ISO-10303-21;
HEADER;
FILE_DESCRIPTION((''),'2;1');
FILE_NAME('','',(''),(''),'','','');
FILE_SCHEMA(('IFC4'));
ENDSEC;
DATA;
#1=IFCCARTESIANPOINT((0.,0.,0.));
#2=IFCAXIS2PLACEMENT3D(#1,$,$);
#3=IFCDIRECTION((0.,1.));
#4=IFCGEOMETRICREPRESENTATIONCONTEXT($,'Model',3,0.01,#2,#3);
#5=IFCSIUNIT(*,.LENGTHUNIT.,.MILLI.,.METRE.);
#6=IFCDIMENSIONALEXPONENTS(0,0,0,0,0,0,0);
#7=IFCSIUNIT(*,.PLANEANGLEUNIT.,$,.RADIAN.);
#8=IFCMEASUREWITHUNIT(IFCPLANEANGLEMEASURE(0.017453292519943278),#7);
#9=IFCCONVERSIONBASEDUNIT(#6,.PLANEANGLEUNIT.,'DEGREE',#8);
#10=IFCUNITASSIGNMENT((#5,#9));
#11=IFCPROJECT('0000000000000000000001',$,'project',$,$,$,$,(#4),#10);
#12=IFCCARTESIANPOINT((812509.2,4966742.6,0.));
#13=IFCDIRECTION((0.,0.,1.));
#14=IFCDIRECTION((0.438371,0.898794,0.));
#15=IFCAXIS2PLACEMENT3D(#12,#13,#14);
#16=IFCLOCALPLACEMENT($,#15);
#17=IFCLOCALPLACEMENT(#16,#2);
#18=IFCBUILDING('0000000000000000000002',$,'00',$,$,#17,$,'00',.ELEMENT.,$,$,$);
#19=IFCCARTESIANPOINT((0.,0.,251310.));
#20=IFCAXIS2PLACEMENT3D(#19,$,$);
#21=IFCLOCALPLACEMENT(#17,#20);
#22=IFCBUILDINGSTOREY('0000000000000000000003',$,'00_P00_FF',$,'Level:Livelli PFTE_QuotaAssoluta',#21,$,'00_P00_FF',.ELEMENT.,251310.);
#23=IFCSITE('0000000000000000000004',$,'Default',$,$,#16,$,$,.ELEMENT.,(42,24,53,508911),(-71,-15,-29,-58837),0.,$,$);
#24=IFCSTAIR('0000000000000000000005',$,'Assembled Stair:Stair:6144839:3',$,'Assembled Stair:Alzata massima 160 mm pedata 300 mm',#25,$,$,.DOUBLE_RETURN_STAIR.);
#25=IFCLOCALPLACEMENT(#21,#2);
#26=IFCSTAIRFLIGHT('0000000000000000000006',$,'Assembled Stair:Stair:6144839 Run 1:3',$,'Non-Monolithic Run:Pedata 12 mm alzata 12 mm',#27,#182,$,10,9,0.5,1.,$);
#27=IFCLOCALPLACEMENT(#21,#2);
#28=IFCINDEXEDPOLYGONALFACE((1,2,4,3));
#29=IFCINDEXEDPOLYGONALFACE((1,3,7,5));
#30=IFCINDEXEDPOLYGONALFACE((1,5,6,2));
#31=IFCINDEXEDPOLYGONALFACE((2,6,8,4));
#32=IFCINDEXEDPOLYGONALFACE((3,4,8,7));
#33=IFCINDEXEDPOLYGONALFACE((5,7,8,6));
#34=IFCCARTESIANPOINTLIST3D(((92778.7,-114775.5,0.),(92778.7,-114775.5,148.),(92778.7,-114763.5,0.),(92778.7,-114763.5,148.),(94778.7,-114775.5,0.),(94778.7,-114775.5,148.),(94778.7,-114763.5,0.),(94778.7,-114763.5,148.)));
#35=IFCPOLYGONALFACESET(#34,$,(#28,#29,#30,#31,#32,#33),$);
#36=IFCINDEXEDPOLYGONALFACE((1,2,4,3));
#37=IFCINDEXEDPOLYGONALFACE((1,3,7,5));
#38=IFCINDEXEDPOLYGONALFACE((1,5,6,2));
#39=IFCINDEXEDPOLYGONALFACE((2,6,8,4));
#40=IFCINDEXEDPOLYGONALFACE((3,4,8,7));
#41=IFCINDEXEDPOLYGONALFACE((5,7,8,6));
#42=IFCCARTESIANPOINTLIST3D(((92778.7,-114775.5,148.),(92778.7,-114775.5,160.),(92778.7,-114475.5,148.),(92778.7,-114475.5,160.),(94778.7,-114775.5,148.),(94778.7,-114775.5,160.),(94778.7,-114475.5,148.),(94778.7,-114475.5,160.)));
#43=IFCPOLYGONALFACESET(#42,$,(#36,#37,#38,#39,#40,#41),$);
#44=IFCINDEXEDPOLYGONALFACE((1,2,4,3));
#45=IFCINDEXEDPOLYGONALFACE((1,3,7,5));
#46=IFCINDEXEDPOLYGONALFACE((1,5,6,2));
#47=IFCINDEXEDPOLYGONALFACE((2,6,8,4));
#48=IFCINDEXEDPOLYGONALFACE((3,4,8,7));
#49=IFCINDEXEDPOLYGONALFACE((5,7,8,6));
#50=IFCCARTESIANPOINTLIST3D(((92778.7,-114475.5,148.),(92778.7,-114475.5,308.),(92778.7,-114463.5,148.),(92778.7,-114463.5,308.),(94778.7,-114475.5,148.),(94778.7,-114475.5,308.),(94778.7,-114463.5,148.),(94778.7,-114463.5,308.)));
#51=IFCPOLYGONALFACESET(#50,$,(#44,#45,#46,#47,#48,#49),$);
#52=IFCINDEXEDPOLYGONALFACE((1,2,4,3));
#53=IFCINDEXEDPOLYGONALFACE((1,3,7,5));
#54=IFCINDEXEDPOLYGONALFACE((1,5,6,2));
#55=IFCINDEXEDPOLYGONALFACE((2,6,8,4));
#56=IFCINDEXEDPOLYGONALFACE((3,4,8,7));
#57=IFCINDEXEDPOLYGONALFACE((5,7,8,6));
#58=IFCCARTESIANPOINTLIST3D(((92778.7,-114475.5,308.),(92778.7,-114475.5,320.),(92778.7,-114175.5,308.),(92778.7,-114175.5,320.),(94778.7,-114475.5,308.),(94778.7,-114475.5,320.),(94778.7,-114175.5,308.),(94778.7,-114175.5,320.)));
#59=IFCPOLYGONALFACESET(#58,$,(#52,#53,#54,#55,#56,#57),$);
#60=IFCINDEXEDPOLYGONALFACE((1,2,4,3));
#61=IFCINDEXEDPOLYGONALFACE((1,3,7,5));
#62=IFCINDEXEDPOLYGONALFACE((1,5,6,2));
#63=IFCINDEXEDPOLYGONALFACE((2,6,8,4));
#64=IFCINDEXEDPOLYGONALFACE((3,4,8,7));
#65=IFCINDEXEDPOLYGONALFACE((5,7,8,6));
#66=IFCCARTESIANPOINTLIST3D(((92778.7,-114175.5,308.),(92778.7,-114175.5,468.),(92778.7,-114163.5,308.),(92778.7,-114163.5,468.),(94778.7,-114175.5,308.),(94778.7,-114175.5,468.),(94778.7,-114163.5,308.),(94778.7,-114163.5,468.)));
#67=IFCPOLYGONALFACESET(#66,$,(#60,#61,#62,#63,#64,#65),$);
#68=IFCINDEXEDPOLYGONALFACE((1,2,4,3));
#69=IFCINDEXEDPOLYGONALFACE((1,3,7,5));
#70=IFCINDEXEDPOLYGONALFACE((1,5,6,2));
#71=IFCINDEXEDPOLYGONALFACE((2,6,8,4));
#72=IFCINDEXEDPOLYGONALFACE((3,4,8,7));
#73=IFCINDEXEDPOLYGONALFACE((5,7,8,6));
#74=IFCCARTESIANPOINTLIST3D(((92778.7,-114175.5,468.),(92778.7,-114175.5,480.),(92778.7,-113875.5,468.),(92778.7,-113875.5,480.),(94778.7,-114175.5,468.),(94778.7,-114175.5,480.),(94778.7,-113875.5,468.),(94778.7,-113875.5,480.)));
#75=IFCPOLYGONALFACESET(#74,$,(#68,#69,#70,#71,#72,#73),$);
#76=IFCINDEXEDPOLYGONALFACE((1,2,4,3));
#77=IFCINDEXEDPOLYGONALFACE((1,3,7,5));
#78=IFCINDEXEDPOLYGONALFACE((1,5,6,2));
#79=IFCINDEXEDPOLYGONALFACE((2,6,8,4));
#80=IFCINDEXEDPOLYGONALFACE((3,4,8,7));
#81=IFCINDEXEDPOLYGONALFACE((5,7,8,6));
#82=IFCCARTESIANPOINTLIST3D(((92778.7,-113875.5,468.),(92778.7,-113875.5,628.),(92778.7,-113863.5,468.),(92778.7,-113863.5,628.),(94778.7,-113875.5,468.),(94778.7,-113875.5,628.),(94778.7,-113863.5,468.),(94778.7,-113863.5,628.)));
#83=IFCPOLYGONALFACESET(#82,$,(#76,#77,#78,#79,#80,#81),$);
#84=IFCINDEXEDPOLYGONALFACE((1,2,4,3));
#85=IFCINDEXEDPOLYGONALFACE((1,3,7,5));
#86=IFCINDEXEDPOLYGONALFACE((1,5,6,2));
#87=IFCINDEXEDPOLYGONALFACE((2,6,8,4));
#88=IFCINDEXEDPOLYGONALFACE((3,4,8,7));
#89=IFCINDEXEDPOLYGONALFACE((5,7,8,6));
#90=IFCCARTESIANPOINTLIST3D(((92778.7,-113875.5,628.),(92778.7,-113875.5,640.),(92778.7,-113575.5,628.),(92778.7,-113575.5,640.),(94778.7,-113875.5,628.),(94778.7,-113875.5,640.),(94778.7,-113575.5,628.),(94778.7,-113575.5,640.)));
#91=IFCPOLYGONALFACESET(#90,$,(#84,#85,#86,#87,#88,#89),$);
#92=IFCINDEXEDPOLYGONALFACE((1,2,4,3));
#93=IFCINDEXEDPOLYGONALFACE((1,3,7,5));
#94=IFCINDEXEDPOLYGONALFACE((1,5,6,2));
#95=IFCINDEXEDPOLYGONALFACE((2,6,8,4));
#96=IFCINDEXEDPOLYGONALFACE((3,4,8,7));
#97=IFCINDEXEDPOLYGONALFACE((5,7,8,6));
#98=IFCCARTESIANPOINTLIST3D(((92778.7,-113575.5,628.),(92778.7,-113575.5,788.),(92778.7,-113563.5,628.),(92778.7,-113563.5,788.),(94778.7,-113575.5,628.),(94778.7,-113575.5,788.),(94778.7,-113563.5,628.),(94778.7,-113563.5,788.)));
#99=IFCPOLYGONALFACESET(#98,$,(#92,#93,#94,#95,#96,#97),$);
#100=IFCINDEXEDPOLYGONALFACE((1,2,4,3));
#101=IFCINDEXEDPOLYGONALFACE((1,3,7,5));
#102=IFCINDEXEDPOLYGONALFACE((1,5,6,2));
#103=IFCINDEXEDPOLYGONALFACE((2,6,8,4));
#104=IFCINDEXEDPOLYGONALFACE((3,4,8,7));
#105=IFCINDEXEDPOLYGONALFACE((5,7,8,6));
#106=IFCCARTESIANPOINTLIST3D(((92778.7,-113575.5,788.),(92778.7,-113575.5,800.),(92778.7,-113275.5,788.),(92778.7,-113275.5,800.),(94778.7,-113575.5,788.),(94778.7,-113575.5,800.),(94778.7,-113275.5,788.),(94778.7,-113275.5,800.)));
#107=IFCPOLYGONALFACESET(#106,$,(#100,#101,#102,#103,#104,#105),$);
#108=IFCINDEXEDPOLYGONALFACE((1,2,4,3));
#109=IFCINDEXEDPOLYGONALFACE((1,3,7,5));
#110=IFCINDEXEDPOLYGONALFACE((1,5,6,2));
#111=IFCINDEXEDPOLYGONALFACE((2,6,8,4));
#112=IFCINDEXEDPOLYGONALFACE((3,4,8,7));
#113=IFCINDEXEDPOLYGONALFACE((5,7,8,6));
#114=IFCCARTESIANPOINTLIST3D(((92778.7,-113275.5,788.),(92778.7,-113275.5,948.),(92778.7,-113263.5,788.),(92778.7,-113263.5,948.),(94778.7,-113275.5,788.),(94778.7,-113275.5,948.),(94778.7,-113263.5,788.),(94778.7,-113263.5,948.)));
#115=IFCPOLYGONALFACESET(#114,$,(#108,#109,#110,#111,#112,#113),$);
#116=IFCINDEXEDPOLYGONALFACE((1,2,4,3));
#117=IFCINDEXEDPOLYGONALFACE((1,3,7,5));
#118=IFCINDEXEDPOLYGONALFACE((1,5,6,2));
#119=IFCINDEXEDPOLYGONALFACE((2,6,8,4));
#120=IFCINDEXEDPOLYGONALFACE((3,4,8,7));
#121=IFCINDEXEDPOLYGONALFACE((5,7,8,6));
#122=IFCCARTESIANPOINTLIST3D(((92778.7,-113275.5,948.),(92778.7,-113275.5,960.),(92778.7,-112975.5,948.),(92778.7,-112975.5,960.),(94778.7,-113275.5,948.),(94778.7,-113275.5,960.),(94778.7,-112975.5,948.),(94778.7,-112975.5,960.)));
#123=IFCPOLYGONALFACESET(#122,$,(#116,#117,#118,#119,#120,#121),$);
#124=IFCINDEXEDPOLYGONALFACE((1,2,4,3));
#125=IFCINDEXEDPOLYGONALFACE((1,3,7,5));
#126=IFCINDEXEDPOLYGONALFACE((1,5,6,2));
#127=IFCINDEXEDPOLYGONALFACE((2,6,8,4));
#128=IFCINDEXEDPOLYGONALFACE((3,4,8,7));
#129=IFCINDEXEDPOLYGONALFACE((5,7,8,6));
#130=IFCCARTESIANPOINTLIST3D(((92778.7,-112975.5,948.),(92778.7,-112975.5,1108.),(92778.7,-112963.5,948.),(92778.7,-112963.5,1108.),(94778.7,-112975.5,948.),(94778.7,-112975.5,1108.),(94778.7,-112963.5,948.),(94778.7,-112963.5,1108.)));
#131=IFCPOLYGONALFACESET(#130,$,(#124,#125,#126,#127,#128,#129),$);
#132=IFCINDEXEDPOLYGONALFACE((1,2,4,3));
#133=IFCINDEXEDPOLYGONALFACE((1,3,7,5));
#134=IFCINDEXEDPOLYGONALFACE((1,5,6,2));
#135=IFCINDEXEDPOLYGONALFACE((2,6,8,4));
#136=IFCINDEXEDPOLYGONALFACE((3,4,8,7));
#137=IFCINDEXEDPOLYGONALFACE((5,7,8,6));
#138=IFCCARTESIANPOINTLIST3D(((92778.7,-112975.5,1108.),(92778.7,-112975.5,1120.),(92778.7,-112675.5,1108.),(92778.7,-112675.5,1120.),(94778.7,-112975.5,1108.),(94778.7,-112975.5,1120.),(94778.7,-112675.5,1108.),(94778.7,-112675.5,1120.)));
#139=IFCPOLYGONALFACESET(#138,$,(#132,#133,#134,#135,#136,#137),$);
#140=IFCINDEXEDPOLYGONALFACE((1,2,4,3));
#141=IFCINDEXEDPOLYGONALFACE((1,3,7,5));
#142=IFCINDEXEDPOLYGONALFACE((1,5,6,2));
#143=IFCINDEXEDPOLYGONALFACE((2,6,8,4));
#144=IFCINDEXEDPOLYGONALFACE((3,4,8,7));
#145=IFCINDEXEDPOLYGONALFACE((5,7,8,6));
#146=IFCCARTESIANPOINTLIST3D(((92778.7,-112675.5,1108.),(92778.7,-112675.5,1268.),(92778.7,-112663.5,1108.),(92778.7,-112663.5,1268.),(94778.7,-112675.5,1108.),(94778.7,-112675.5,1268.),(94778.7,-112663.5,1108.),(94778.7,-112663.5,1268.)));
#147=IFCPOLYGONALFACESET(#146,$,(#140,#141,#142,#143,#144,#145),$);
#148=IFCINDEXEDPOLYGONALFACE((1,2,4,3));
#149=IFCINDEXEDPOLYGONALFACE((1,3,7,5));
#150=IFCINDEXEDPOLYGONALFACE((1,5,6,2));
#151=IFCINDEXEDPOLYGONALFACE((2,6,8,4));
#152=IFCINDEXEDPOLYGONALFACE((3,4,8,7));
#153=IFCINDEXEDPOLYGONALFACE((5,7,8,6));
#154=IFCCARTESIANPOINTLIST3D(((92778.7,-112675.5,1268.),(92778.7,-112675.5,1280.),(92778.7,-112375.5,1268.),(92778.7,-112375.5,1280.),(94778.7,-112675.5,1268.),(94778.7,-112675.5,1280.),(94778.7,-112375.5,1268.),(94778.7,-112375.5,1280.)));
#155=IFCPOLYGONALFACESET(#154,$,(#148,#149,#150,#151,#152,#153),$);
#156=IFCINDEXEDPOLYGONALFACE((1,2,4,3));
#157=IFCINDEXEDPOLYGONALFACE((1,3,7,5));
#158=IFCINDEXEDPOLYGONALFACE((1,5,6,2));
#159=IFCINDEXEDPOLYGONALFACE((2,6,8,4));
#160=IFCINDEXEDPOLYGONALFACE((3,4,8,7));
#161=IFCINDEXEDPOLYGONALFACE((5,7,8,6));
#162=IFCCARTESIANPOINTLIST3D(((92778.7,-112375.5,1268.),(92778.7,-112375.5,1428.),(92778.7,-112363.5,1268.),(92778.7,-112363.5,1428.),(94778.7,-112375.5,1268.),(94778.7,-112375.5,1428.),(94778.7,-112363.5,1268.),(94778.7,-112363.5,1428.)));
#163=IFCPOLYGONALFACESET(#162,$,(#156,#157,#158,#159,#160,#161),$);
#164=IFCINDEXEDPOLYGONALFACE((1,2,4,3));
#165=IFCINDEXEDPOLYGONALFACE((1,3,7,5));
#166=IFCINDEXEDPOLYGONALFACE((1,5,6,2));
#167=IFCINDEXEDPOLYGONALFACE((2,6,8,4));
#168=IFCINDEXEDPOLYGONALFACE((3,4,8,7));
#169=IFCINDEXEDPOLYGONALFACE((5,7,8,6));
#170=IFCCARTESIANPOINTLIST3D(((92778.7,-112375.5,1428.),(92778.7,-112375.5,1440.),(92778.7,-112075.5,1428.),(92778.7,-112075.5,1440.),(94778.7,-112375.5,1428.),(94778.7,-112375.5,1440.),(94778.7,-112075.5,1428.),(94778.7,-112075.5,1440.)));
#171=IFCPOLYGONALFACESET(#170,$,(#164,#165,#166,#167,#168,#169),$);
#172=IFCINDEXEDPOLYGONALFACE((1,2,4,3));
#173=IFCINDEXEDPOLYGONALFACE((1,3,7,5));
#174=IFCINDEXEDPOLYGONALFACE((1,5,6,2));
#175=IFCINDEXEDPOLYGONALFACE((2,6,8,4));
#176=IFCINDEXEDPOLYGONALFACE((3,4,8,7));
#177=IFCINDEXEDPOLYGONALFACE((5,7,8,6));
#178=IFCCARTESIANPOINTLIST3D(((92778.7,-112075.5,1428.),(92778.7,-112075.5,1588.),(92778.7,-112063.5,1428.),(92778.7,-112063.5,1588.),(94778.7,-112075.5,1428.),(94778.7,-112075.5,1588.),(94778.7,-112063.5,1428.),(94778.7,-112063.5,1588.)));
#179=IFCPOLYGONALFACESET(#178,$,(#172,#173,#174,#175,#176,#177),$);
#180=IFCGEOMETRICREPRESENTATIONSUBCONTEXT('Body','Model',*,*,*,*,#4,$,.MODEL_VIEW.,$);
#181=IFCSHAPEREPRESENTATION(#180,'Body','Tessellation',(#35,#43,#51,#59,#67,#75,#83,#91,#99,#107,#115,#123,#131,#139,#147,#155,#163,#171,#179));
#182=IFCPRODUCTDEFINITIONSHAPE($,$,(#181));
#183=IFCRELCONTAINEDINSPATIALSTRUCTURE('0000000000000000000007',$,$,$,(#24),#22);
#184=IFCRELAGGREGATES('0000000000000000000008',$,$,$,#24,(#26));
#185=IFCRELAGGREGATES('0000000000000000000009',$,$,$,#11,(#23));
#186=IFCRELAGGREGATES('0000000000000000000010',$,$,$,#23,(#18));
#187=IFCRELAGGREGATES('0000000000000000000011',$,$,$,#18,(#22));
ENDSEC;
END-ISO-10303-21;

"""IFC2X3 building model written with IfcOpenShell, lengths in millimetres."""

from ifc_helpers import new_model, entity, si_unit, converted_unit, direction, frame, frame_2d, origin, origin_2d_with_axis, place, context, subcontext, project, spatial, rectangle, extrude, element, aggregate, save


model = new_model("IFC2X3")

# Units and contexts
model_context = context("Model", 3, precision=0.01, world=origin(), true_north=direction((0.0, 1.0)))
body_context = subcontext(model_context, "Body", "Model", "MODEL_VIEW")
ifc_project = project(units=[si_unit("LENGTHUNIT", "METRE", prefix="MILLI"), converted_unit("PLANEANGLEUNIT", "DEGREE", entity("IfcPlaneAngleMeasure", 0.017453292519943278), si_unit("PLANEANGLEUNIT", "RADIAN"), dimensions=[0, 0, 0, 0, 0, 0, 0])], contexts=[model_context])

# Site, building, storey
site_placement = place(None, frame((812509.2, 4966742.6, 0.0), z_axis=(0.0, 0.0, 1.0), x_axis=(0.438371, 0.898794, 0.0)))
site = spatial("IfcSite", under=ifc_project, at=site_placement, Name="Default", CompositionType="ELEMENT", RefLatitude=(42, 24, 53, 508911), RefLongitude=(-71, -15, -29, -58837), RefElevation=0.0)
building_placement = place(site_placement, origin())
building = spatial("IfcBuilding", under=site, at=building_placement, Name="00", LongName="00", CompositionType="ELEMENT")
storey_placement = place(building_placement, frame((0.0, 0.0, 251310.0)))
storey = spatial("IfcBuildingStorey", under=building, at=storey_placement, Name="00_P00_FF", ObjectType="Level:Livelli PFTE_QuotaAssoluta", LongName="00_P00_FF", CompositionType="ELEMENT", Elevation=251310.0)

# Stair
stair_1_placement = place(storey_placement, origin())
stair_1 = element("IfcStair", 1, at=stair_1_placement, inside=storey, Name="Assembled Stair:Stair:6144839:3", ObjectType="Assembled Stair:Alzata massima 160 mm pedata 300 mm", ShapeType="DOUBLE_RETURN_STAIR")

# Stair flight
stair_flight_1_placement = place(stair_1_placement, origin())
stair_flight_1 = element("IfcStairFlight", 2, at=stair_flight_1_placement, Name="Assembled Stair:Stair:6144839 Run 1:3", ObjectType="Non-Monolithic Run:Pedata 12 mm alzata 12 mm", NumberOfRiser=10, NumberOfTreads=9, RiserHeight=0.5, TreadLength=1.0, context=body_context, shape_type="SweptSolid", body=[
    extrude(rectangle(XDim=2000.0, YDim=12.0, at=origin_2d_with_axis()), frame((93778.7, -114769.5, 0.0), z_axis=(0.0, 0.0, 1.0), x_axis=(-1.0, 0.0, 0.0)), (0.0, 0.0, 1.0), 148.0),
    extrude(rectangle(XDim=300.0, YDim=2000.0, at=frame_2d((0.0, 0.0), x_axis=(1.0, 0.0))), frame((93778.7, -114625.5, 148.0), z_axis=(0.0, 0.0, 1.0), x_axis=(0.0, -1.0, 0.0)), (0.0, 0.0, 1.0), 12.0),
    extrude(rectangle(XDim=2000.0, YDim=12.0, at=frame_2d((0.0, 0.0), x_axis=(1.0, 0.0))), frame((93778.7, -114469.5, 148.0), z_axis=(0.0, 0.0, 1.0), x_axis=(-1.0, 0.0, 0.0)), (0.0, 0.0, 1.0), 160.0),
    extrude(rectangle(XDim=300.0, YDim=2000.0, at=frame_2d((0.0, 0.0), x_axis=(1.0, 0.0))), frame((93778.7, -114325.5, 308.0), z_axis=(0.0, 0.0, 1.0), x_axis=(0.0, -1.0, 0.0)), (0.0, 0.0, 1.0), 12.0),
    extrude(rectangle(XDim=2000.0, YDim=12.0, at=frame_2d((0.0, 0.0), x_axis=(1.0, 0.0))), frame((93778.7, -114169.5, 308.0), z_axis=(0.0, 0.0, 1.0), x_axis=(-1.0, 0.0, 0.0)), (0.0, 0.0, 1.0), 160.0),
    extrude(rectangle(XDim=300.0, YDim=2000.0, at=frame_2d((0.0, 0.0), x_axis=(1.0, 0.0))), frame((93778.7, -114025.5, 468.0), z_axis=(0.0, 0.0, 1.0), x_axis=(0.0, -1.0, 0.0)), (0.0, 0.0, 1.0), 12.0),
    extrude(rectangle(XDim=2000.0, YDim=12.0, at=frame_2d((0.0, 0.0), x_axis=(1.0, 0.0))), frame((93778.7, -113869.5, 468.0), z_axis=(0.0, 0.0, 1.0), x_axis=(-1.0, 0.0, 0.0)), (0.0, 0.0, 1.0), 160.0),
    extrude(rectangle(XDim=300.0, YDim=2000.0, at=frame_2d((0.0, 0.0), x_axis=(1.0, 0.0))), frame((93778.7, -113725.5, 628.0), z_axis=(0.0, 0.0, 1.0), x_axis=(0.0, -1.0, 0.0)), (0.0, 0.0, 1.0), 12.0),
    extrude(rectangle(XDim=2000.0, YDim=12.0, at=frame_2d((0.0, 0.0), x_axis=(1.0, 0.0))), frame((93778.7, -113569.5, 628.0), z_axis=(0.0, 0.0, 1.0), x_axis=(-1.0, 0.0, 0.0)), (0.0, 0.0, 1.0), 160.0),
    extrude(rectangle(XDim=300.0, YDim=2000.0, at=frame_2d((0.0, 0.0), x_axis=(1.0, 0.0))), frame((93778.7, -113425.5, 788.0), z_axis=(0.0, 0.0, 1.0), x_axis=(0.0, -1.0, 0.0)), (0.0, 0.0, 1.0), 12.0),
    extrude(rectangle(XDim=2000.0, YDim=12.0, at=frame_2d((0.0, 0.0), x_axis=(1.0, 0.0))), frame((93778.7, -113269.5, 788.0), z_axis=(0.0, 0.0, 1.0), x_axis=(-1.0, 0.0, 0.0)), (0.0, 0.0, 1.0), 160.0),
    extrude(rectangle(XDim=300.0, YDim=2000.0, at=frame_2d((0.0, 0.0), x_axis=(1.0, 0.0))), frame((93778.7, -113125.5, 948.0), z_axis=(0.0, 0.0, 1.0), x_axis=(0.0, -1.0, 0.0)), (0.0, 0.0, 1.0), 12.0),
    extrude(rectangle(XDim=2000.0, YDim=12.0, at=frame_2d((0.0, 0.0), x_axis=(1.0, 0.0))), frame((93778.7, -112969.5, 948.0), z_axis=(0.0, 0.0, 1.0), x_axis=(-1.0, 0.0, 0.0)), (0.0, 0.0, 1.0), 160.0),
    extrude(rectangle(XDim=300.0, YDim=2000.0, at=frame_2d((0.0, 0.0), x_axis=(1.0, 0.0))), frame((93778.7, -112825.5, 1108.0), z_axis=(0.0, 0.0, 1.0), x_axis=(0.0, -1.0, 0.0)), (0.0, 0.0, 1.0), 12.0),
    extrude(rectangle(XDim=2000.0, YDim=12.0, at=frame_2d((0.0, 0.0), x_axis=(1.0, 0.0))), frame((93778.7, -112669.5, 1108.0), z_axis=(0.0, 0.0, 1.0), x_axis=(-1.0, 0.0, 0.0)), (0.0, 0.0, 1.0), 160.0),
    extrude(rectangle(XDim=300.0, YDim=2000.0, at=frame_2d((0.0, 0.0), x_axis=(1.0, 0.0))), frame((93778.7, -112525.5, 1268.0), z_axis=(0.0, 0.0, 1.0), x_axis=(0.0, -1.0, 0.0)), (0.0, 0.0, 1.0), 12.0),
    extrude(rectangle(XDim=2000.0, YDim=12.0, at=frame_2d((0.0, 0.0), x_axis=(1.0, 0.0))), frame((93778.7, -112369.5, 1268.0), z_axis=(0.0, 0.0, 1.0), x_axis=(-1.0, 0.0, 0.0)), (0.0, 0.0, 1.0), 160.0),
    extrude(rectangle(XDim=300.0, YDim=2000.0, at=frame_2d((0.0, 0.0), x_axis=(1.0, 0.0))), frame((93778.7, -112225.5, 1428.0), z_axis=(0.0, 0.0, 1.0), x_axis=(0.0, -1.0, 0.0)), (0.0, 0.0, 1.0), 12.0),
    extrude(rectangle(XDim=2000.0, YDim=12.0, at=origin_2d_with_axis()), frame((93778.7, -112069.5, 1428.0), z_axis=(0.0, 0.0, 1.0), x_axis=(-1.0, 0.0, 0.0)), (0.0, 0.0, 1.0), 160.0),
])
aggregate(stair_1, [stair_flight_1])

save(model, "model.ifc")
